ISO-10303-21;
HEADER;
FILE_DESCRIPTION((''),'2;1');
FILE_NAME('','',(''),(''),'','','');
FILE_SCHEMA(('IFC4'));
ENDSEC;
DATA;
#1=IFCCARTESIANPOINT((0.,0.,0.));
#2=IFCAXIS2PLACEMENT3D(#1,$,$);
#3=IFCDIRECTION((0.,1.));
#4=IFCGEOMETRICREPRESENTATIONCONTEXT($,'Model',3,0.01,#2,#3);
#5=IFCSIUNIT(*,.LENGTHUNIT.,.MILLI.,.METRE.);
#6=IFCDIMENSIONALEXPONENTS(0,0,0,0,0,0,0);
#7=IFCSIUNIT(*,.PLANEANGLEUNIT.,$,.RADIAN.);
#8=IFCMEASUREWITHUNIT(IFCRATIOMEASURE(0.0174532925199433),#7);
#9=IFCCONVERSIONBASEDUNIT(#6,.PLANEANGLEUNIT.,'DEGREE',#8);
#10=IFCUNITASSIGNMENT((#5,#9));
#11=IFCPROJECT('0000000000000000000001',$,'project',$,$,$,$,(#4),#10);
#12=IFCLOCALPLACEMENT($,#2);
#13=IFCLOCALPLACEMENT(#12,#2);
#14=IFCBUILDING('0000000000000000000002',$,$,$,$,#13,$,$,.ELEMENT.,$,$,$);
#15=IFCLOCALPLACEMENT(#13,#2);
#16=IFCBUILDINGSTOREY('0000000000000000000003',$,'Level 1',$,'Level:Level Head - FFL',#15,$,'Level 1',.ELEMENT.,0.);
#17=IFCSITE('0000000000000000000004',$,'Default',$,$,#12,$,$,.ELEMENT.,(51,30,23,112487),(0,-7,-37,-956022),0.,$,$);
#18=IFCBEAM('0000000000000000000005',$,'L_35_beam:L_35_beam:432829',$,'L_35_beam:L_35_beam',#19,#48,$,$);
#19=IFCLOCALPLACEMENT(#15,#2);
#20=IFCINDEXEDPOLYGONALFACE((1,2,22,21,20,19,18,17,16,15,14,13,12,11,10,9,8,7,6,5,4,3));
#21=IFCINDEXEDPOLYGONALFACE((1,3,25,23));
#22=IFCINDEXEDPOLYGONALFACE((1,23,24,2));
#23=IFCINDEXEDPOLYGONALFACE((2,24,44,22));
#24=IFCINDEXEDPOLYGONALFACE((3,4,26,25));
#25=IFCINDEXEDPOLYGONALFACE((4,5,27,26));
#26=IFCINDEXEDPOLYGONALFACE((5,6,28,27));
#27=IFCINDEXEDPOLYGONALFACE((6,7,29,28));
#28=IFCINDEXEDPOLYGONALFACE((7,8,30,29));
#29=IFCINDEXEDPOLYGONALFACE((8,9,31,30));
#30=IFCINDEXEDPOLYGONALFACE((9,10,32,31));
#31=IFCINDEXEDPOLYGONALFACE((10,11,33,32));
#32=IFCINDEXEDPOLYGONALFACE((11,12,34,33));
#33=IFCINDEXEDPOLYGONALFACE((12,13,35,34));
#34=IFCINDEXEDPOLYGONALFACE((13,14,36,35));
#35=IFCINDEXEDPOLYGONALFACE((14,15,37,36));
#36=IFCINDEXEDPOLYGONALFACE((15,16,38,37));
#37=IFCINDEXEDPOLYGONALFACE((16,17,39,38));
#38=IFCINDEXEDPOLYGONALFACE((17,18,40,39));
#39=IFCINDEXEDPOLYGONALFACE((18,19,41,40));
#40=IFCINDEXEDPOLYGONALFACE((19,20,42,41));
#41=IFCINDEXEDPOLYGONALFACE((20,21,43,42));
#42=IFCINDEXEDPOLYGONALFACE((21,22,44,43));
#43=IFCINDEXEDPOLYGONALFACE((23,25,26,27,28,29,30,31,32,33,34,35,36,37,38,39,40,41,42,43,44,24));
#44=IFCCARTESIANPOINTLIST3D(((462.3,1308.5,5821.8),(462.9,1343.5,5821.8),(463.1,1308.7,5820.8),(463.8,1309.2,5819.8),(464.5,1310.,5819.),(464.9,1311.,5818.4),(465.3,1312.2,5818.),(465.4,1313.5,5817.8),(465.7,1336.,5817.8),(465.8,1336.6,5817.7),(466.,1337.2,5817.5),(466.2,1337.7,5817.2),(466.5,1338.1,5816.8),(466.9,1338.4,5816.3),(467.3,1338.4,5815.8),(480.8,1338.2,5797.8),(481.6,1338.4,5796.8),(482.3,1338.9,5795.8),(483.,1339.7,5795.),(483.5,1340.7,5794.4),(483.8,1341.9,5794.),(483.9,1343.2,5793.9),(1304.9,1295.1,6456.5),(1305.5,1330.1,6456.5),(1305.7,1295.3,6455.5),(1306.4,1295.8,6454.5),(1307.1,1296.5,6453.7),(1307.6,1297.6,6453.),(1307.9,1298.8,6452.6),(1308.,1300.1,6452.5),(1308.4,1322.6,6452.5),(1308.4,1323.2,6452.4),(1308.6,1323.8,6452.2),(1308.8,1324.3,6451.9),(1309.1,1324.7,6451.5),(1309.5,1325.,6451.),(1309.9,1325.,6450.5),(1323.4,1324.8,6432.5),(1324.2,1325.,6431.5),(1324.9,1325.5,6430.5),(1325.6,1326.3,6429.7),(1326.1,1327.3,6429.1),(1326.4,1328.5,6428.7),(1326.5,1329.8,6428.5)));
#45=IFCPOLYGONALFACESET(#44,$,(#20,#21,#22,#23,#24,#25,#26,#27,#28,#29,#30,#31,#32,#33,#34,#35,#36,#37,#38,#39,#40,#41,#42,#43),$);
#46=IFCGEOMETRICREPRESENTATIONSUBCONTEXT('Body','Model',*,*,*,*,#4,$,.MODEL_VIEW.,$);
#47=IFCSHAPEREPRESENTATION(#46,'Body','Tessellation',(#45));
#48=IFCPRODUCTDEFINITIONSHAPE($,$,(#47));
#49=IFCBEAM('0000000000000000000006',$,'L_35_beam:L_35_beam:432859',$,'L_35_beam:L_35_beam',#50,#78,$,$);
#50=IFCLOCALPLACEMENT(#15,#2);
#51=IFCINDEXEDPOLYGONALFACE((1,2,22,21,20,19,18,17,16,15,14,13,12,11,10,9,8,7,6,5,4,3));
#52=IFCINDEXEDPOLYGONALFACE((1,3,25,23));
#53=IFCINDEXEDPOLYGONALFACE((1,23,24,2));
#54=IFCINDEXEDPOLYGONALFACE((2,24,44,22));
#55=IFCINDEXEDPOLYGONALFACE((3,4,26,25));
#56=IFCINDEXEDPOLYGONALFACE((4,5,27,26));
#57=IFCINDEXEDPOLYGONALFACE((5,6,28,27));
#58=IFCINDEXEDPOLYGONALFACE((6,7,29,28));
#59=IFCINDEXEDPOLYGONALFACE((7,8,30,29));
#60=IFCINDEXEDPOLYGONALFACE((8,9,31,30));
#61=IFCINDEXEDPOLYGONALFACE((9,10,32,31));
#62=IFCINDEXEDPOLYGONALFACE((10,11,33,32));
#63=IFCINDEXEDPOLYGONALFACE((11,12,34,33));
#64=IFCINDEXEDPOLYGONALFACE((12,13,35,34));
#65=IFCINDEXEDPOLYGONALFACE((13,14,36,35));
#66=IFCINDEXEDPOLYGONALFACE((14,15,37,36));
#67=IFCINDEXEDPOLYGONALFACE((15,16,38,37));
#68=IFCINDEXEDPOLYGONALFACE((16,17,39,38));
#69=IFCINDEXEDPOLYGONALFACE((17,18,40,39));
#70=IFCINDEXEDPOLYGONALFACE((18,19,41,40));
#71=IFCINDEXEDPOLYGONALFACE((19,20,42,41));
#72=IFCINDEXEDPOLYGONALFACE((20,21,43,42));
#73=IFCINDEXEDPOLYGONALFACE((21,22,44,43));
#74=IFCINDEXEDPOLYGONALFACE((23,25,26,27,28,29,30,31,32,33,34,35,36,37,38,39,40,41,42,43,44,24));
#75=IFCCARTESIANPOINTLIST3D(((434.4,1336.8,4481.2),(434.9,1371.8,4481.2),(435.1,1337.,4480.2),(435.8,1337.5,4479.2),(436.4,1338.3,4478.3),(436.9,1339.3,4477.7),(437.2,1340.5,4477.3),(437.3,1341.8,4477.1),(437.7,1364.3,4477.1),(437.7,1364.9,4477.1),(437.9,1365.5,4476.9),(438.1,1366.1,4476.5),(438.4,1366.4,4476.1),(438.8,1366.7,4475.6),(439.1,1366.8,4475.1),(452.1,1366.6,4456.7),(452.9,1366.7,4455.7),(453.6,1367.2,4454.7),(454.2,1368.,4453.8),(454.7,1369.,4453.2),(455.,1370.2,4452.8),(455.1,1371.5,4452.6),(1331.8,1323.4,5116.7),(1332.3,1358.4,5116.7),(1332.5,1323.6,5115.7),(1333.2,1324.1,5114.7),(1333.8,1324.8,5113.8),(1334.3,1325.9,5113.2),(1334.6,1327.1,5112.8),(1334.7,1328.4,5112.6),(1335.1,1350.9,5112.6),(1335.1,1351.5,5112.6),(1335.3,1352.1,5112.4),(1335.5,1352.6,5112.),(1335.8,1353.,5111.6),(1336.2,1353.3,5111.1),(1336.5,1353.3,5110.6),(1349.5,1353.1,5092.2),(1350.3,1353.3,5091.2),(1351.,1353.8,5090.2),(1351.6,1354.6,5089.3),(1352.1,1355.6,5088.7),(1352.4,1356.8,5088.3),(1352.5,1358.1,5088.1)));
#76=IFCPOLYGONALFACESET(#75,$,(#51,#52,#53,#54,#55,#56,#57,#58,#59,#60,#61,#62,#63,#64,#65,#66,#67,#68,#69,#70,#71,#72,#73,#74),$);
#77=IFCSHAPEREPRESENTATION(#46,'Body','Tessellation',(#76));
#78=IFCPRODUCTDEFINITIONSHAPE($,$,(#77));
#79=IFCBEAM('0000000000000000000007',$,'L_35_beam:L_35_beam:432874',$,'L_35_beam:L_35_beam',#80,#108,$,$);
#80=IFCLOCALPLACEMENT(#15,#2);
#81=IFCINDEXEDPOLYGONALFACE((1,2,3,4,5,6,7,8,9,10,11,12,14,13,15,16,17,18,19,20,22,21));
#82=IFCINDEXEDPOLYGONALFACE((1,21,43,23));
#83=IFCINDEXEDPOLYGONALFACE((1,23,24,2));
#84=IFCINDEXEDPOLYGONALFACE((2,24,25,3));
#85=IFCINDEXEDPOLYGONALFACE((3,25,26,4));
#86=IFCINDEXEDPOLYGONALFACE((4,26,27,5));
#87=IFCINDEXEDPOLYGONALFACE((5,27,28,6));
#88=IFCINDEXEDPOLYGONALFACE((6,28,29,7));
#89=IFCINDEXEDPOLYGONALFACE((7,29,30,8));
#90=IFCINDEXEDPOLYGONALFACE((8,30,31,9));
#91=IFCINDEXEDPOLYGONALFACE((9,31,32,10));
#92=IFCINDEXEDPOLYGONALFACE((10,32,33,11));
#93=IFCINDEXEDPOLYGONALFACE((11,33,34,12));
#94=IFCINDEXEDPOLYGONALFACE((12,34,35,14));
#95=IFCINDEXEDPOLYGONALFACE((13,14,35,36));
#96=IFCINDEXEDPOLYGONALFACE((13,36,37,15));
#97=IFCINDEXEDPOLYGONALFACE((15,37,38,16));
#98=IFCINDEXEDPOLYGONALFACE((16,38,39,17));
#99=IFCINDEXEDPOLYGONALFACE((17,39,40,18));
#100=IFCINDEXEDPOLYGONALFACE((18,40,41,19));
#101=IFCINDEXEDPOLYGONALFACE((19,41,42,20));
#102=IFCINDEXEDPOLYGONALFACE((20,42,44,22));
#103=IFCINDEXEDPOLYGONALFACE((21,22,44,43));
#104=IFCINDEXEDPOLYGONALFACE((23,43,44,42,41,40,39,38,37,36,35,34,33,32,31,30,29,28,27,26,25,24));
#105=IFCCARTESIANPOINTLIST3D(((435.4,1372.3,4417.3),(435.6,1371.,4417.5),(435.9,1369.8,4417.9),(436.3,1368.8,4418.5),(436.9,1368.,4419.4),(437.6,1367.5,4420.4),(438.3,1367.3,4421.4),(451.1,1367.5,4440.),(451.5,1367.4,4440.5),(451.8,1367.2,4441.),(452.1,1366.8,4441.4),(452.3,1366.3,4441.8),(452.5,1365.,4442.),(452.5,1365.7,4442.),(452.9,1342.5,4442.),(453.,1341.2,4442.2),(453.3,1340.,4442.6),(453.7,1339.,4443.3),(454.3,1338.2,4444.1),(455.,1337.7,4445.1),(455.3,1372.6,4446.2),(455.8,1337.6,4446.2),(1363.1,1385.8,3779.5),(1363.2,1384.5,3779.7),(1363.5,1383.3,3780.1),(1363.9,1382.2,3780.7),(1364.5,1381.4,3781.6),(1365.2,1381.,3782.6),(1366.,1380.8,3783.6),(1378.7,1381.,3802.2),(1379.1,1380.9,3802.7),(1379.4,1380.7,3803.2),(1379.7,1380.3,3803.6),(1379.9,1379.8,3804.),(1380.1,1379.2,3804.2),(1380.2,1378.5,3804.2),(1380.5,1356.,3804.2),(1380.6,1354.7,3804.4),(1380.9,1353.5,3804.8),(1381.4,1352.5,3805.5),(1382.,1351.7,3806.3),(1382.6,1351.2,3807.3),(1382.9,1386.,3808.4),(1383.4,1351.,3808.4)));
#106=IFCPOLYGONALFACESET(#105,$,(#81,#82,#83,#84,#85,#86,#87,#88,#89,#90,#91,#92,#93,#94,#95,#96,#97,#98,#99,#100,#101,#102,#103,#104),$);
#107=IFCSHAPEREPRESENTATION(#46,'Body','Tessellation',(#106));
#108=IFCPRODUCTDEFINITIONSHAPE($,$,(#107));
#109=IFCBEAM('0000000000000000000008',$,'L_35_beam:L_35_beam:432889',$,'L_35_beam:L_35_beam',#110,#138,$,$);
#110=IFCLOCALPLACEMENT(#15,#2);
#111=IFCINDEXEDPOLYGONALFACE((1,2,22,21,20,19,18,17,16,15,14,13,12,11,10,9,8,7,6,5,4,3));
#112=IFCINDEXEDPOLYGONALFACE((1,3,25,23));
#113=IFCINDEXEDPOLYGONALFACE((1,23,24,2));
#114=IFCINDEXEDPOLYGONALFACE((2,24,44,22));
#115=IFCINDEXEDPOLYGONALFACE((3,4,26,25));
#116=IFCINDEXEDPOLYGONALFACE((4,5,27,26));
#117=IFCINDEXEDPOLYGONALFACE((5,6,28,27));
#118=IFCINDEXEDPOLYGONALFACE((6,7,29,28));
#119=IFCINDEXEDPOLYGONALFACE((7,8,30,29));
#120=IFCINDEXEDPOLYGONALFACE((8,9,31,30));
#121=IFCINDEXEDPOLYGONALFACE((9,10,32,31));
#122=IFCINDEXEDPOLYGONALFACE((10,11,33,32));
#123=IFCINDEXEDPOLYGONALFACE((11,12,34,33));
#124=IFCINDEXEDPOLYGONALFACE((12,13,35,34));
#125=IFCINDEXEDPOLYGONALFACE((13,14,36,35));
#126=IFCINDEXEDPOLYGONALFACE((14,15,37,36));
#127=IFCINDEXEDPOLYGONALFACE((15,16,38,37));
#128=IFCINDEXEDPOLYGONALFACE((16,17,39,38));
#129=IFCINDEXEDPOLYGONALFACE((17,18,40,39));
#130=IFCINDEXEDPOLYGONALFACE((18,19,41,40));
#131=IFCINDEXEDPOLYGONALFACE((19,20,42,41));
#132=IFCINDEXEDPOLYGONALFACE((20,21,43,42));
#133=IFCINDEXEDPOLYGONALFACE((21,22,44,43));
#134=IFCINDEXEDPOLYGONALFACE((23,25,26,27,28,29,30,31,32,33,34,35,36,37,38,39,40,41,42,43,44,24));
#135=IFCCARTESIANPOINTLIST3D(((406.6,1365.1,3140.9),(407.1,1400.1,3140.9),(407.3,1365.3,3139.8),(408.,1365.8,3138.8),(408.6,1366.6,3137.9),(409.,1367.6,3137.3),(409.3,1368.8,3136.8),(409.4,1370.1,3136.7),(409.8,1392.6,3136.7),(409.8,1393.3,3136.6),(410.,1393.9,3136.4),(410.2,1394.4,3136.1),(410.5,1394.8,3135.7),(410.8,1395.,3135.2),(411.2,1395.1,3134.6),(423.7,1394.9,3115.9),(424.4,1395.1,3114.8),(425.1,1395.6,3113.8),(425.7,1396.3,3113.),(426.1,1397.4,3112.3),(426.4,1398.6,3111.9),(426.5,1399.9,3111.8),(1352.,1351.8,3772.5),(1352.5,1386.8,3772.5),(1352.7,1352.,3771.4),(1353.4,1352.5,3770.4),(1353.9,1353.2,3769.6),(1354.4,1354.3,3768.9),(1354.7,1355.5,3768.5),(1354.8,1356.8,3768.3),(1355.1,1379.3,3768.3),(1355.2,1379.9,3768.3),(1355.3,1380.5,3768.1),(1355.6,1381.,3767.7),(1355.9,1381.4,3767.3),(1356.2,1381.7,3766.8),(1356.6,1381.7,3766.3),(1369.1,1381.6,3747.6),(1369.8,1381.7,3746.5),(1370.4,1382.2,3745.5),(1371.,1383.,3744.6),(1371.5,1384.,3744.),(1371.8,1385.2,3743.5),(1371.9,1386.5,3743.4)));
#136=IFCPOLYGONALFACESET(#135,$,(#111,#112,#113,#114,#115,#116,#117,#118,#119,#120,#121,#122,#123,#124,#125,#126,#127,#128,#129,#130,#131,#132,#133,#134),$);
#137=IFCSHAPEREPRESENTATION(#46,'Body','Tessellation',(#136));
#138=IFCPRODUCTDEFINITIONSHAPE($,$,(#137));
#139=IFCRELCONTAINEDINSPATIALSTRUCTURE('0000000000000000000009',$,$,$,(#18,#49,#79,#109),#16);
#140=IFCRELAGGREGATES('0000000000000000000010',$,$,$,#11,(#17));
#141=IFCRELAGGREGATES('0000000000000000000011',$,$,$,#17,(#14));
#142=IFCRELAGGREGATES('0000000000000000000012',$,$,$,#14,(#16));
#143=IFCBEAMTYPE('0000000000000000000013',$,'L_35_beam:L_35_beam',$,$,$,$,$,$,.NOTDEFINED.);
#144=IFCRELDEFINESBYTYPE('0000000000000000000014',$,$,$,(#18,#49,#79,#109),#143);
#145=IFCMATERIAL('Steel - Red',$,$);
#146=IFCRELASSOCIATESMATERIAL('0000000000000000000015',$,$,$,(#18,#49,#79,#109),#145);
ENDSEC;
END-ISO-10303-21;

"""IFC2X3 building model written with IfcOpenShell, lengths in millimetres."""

from ifc_helpers import new_model, entity, si_unit, converted_unit, direction, frame, frame_2d, origin, place, context, subcontext, project, spatial, polyline, circle_curve, parameter, trimmed, segment, composite_curve, outline, extrude, material, type_object, element, save


model = new_model("IFC2X3")

# Units and contexts
model_context = context("Model", 3, precision=0.01, world=origin(), true_north=direction((0.0, 1.0)))
body_context = subcontext(model_context, "Body", "Model", "MODEL_VIEW")
ifc_project = project(units=[si_unit("LENGTHUNIT", "METRE", prefix="MILLI"), converted_unit("PLANEANGLEUNIT", "DEGREE", entity("IfcRatioMeasure", 0.0174532925199433), si_unit("PLANEANGLEUNIT", "RADIAN"), dimensions=[0, 0, 0, 0, 0, 0, 0])], contexts=[model_context])

# Site, building, storey
site_placement = place(None, origin())
site = spatial("IfcSite", under=ifc_project, at=site_placement, Name="Default", CompositionType="ELEMENT", RefLatitude=(51, 30, 23, 112487), RefLongitude=(0, -7, -37, -956022), RefElevation=0.0)
building_placement = place(site_placement, origin())
building = spatial("IfcBuilding", under=site, at=building_placement, CompositionType="ELEMENT")
storey_placement = place(building_placement, origin())
storey = spatial("IfcBuildingStorey", under=building, at=storey_placement, Name="Level 1", ObjectType="Level:Level Head - FFL", LongName="Level 1", CompositionType="ELEMENT", Elevation=0.0)

# Beams
ifc_material_1 = material(Name="Steel - Red")
beam_type = type_object("IfcBeamType", Name="L_35_beam:L_35_beam", PredefinedType="NOTDEFINED")
beam_1_placement = place(storey_placement, frame((448.3, 1351.8, 5788.8), z_axis=(-0.60153, 0.009574, 0.798793), x_axis=(0.798692, -0.012712, 0.601606)))
element("IfcBeam", 1, at=beam_1_placement, inside=storey, type_object=beam_type, material=ifc_material_1, Name="L_35_beam:L_35_beam:432829", ObjectType="L_35_beam:L_35_beam", context=body_context, shape_type="SweptSolid", body=[
    extrude(outline(composite_curve([segment(polyline([(-23.2, -11.8), (11.8, -11.8)]), True, "CONTINUOUS"), segment(polyline([(11.8, -11.8), (11.8, 23.2)]), True, "CONTINUOUS"), segment(trimmed(circle_curve(frame_2d((11.8, 18.2), x_axis=(0.0, 1.0)), 5.0), [parameter(0.0)], [parameter(90.0)], True, "PARAMETER"), True, "CONTINUOUS"), segment(polyline([(6.8, 18.2), (6.8, -4.3)]), True, "CONTINUOUS"), segment(trimmed(circle_curve(frame_2d((4.3, -4.3), x_axis=(1.0, 0.0)), 2.5), [parameter(270.0)], [parameter(0.0)], True, "PARAMETER"), False, "CONTINUOUS"), segment(polyline([(4.3, -6.8), (-18.2, -6.8)]), True, "CONTINUOUS"), segment(trimmed(circle_curve(frame_2d((-18.2, -11.8), x_axis=(0.0, 1.0)), 5.0), [parameter(0.0)], [parameter(90.0)], True, "PARAMETER"), True, "CONTINUOUS")], self_intersect=False)), frame((31.6, -19.8, 5.7), z_axis=(1.0, 0.0, 0.0), x_axis=(0.0, 0.0, 1.0)), (0.0, 0.0, 1.0), 1055.0),
])
beam_2_placement = place(storey_placement, frame((420.0, 1380.1, 4449.1), z_axis=(-0.577808, 0.008646, 0.816127), x_axis=(0.816035, -0.01221, 0.577873)))
element("IfcBeam", 2, at=beam_2_placement, inside=storey, type_object=beam_type, material=ifc_material_1, Name="L_35_beam:L_35_beam:432859", ObjectType="L_35_beam:L_35_beam", context=body_context, shape_type="SweptSolid", body=[
    extrude(outline(composite_curve([segment(polyline([(-23.2, -11.8), (11.8, -11.8)]), True, "CONTINUOUS"), segment(polyline([(11.8, -11.8), (11.8, 23.2)]), True, "CONTINUOUS"), segment(trimmed(circle_curve(frame_2d((11.8, 18.2), x_axis=(0.0, 1.0)), 5.0), [parameter(0.0)], [parameter(90.0)], True, "PARAMETER"), True, "CONTINUOUS"), segment(polyline([(6.8, 18.2), (6.8, -4.3)]), True, "CONTINUOUS"), segment(trimmed(circle_curve(frame_2d((4.3, -4.3), x_axis=(1.0, 0.0)), 2.5), [parameter(270.0)], [parameter(0.0)], True, "PARAMETER"), False, "CONTINUOUS"), segment(polyline([(4.3, -6.8), (-18.2, -6.8)]), True, "CONTINUOUS"), segment(trimmed(circle_curve(frame_2d((-18.2, -11.8), x_axis=(0.0, 1.0)), 5.0), [parameter(0.0)], [parameter(90.0)], True, "PARAMETER"), True, "CONTINUOUS")], self_intersect=False)), frame((30.8, -19.8, 5.7), z_axis=(1.0, 0.0, 0.0), x_axis=(0.0, 0.0, 1.0)), (0.0, 0.0, 1.0), 1099.7),
])
beam_3_placement = place(storey_placement, frame((420.0, 1380.1, 4449.1), z_axis=(0.566466, 0.00823, 0.824044), x_axis=(0.823957, 0.01197, -0.566525)))
element("IfcBeam", 3, at=beam_3_placement, inside=storey, type_object=beam_type, material=ifc_material_1, Name="L_35_beam:L_35_beam:432874", ObjectType="L_35_beam:L_35_beam", context=body_context, shape_type="SweptSolid", body=[
    extrude(outline(composite_curve([segment(polyline([(-23.2, -11.8), (11.8, -11.8)]), True, "CONTINUOUS"), segment(polyline([(11.8, -11.8), (11.8, 23.2)]), True, "CONTINUOUS"), segment(trimmed(circle_curve(frame_2d((11.8, 18.2), x_axis=(0.0, 1.0)), 5.0), [parameter(0.0)], [parameter(90.0)], True, "PARAMETER"), True, "CONTINUOUS"), segment(polyline([(6.8, 18.2), (6.8, -4.3)]), True, "CONTINUOUS"), segment(trimmed(circle_curve(frame_2d((4.3, -4.3), x_axis=(1.0, 0.0)), 2.5), [parameter(270.0)], [parameter(0.0)], True, "PARAMETER"), False, "CONTINUOUS"), segment(polyline([(4.3, -6.8), (-18.2, -6.8)]), True, "CONTINUOUS"), segment(trimmed(circle_curve(frame_2d((-18.2, -11.8), x_axis=(0.0, 1.0)), 5.0), [parameter(0.0)], [parameter(90.0)], True, "PARAMETER"), True, "CONTINUOUS")], self_intersect=False)), frame((30.7, -19.8, 5.7), z_axis=(1.0, 0.0, 0.0), x_axis=(0.0, 0.0, 1.0)), (0.0, 0.0, 1.0), 1125.8),
])
beam_4_placement = place(storey_placement, frame((391.6, 1408.4, 3109.4), z_axis=(-0.555459, 0.007842, 0.831507), x_axis=(0.831424, -0.011738, 0.555515)))
element("IfcBeam", 4, at=beam_4_placement, inside=storey, type_object=beam_type, material=ifc_material_1, Name="L_35_beam:L_35_beam:432889", ObjectType="L_35_beam:L_35_beam", context=body_context, shape_type="SweptSolid", body=[
    extrude(outline(composite_curve([segment(polyline([(-23.2, -11.8), (11.8, -11.8)]), True, "CONTINUOUS"), segment(polyline([(11.8, -11.8), (11.8, 23.2)]), True, "CONTINUOUS"), segment(trimmed(circle_curve(frame_2d((11.8, 18.2), x_axis=(0.0, 1.0)), 5.0), [parameter(0.0)], [parameter(90.0)], True, "PARAMETER"), True, "CONTINUOUS"), segment(polyline([(6.8, 18.2), (6.8, -4.3)]), True, "CONTINUOUS"), segment(trimmed(circle_curve(frame_2d((4.3, -4.3), x_axis=(1.0, 0.0)), 2.5), [parameter(270.0)], [parameter(0.0)], True, "PARAMETER"), False, "CONTINUOUS"), segment(polyline([(4.3, -6.8), (-18.2, -6.8)]), True, "CONTINUOUS"), segment(trimmed(circle_curve(frame_2d((-18.2, -11.8), x_axis=(0.0, 1.0)), 5.0), [parameter(0.0)], [parameter(90.0)], True, "PARAMETER"), True, "CONTINUOUS")], self_intersect=False)), frame((30.4, -19.8, 5.7), z_axis=(1.0, 0.0, 0.0), x_axis=(0.0, 0.0, 1.0)), (0.0, 0.0, 1.0), 1137.0),
])

save(model, "model.ifc")
